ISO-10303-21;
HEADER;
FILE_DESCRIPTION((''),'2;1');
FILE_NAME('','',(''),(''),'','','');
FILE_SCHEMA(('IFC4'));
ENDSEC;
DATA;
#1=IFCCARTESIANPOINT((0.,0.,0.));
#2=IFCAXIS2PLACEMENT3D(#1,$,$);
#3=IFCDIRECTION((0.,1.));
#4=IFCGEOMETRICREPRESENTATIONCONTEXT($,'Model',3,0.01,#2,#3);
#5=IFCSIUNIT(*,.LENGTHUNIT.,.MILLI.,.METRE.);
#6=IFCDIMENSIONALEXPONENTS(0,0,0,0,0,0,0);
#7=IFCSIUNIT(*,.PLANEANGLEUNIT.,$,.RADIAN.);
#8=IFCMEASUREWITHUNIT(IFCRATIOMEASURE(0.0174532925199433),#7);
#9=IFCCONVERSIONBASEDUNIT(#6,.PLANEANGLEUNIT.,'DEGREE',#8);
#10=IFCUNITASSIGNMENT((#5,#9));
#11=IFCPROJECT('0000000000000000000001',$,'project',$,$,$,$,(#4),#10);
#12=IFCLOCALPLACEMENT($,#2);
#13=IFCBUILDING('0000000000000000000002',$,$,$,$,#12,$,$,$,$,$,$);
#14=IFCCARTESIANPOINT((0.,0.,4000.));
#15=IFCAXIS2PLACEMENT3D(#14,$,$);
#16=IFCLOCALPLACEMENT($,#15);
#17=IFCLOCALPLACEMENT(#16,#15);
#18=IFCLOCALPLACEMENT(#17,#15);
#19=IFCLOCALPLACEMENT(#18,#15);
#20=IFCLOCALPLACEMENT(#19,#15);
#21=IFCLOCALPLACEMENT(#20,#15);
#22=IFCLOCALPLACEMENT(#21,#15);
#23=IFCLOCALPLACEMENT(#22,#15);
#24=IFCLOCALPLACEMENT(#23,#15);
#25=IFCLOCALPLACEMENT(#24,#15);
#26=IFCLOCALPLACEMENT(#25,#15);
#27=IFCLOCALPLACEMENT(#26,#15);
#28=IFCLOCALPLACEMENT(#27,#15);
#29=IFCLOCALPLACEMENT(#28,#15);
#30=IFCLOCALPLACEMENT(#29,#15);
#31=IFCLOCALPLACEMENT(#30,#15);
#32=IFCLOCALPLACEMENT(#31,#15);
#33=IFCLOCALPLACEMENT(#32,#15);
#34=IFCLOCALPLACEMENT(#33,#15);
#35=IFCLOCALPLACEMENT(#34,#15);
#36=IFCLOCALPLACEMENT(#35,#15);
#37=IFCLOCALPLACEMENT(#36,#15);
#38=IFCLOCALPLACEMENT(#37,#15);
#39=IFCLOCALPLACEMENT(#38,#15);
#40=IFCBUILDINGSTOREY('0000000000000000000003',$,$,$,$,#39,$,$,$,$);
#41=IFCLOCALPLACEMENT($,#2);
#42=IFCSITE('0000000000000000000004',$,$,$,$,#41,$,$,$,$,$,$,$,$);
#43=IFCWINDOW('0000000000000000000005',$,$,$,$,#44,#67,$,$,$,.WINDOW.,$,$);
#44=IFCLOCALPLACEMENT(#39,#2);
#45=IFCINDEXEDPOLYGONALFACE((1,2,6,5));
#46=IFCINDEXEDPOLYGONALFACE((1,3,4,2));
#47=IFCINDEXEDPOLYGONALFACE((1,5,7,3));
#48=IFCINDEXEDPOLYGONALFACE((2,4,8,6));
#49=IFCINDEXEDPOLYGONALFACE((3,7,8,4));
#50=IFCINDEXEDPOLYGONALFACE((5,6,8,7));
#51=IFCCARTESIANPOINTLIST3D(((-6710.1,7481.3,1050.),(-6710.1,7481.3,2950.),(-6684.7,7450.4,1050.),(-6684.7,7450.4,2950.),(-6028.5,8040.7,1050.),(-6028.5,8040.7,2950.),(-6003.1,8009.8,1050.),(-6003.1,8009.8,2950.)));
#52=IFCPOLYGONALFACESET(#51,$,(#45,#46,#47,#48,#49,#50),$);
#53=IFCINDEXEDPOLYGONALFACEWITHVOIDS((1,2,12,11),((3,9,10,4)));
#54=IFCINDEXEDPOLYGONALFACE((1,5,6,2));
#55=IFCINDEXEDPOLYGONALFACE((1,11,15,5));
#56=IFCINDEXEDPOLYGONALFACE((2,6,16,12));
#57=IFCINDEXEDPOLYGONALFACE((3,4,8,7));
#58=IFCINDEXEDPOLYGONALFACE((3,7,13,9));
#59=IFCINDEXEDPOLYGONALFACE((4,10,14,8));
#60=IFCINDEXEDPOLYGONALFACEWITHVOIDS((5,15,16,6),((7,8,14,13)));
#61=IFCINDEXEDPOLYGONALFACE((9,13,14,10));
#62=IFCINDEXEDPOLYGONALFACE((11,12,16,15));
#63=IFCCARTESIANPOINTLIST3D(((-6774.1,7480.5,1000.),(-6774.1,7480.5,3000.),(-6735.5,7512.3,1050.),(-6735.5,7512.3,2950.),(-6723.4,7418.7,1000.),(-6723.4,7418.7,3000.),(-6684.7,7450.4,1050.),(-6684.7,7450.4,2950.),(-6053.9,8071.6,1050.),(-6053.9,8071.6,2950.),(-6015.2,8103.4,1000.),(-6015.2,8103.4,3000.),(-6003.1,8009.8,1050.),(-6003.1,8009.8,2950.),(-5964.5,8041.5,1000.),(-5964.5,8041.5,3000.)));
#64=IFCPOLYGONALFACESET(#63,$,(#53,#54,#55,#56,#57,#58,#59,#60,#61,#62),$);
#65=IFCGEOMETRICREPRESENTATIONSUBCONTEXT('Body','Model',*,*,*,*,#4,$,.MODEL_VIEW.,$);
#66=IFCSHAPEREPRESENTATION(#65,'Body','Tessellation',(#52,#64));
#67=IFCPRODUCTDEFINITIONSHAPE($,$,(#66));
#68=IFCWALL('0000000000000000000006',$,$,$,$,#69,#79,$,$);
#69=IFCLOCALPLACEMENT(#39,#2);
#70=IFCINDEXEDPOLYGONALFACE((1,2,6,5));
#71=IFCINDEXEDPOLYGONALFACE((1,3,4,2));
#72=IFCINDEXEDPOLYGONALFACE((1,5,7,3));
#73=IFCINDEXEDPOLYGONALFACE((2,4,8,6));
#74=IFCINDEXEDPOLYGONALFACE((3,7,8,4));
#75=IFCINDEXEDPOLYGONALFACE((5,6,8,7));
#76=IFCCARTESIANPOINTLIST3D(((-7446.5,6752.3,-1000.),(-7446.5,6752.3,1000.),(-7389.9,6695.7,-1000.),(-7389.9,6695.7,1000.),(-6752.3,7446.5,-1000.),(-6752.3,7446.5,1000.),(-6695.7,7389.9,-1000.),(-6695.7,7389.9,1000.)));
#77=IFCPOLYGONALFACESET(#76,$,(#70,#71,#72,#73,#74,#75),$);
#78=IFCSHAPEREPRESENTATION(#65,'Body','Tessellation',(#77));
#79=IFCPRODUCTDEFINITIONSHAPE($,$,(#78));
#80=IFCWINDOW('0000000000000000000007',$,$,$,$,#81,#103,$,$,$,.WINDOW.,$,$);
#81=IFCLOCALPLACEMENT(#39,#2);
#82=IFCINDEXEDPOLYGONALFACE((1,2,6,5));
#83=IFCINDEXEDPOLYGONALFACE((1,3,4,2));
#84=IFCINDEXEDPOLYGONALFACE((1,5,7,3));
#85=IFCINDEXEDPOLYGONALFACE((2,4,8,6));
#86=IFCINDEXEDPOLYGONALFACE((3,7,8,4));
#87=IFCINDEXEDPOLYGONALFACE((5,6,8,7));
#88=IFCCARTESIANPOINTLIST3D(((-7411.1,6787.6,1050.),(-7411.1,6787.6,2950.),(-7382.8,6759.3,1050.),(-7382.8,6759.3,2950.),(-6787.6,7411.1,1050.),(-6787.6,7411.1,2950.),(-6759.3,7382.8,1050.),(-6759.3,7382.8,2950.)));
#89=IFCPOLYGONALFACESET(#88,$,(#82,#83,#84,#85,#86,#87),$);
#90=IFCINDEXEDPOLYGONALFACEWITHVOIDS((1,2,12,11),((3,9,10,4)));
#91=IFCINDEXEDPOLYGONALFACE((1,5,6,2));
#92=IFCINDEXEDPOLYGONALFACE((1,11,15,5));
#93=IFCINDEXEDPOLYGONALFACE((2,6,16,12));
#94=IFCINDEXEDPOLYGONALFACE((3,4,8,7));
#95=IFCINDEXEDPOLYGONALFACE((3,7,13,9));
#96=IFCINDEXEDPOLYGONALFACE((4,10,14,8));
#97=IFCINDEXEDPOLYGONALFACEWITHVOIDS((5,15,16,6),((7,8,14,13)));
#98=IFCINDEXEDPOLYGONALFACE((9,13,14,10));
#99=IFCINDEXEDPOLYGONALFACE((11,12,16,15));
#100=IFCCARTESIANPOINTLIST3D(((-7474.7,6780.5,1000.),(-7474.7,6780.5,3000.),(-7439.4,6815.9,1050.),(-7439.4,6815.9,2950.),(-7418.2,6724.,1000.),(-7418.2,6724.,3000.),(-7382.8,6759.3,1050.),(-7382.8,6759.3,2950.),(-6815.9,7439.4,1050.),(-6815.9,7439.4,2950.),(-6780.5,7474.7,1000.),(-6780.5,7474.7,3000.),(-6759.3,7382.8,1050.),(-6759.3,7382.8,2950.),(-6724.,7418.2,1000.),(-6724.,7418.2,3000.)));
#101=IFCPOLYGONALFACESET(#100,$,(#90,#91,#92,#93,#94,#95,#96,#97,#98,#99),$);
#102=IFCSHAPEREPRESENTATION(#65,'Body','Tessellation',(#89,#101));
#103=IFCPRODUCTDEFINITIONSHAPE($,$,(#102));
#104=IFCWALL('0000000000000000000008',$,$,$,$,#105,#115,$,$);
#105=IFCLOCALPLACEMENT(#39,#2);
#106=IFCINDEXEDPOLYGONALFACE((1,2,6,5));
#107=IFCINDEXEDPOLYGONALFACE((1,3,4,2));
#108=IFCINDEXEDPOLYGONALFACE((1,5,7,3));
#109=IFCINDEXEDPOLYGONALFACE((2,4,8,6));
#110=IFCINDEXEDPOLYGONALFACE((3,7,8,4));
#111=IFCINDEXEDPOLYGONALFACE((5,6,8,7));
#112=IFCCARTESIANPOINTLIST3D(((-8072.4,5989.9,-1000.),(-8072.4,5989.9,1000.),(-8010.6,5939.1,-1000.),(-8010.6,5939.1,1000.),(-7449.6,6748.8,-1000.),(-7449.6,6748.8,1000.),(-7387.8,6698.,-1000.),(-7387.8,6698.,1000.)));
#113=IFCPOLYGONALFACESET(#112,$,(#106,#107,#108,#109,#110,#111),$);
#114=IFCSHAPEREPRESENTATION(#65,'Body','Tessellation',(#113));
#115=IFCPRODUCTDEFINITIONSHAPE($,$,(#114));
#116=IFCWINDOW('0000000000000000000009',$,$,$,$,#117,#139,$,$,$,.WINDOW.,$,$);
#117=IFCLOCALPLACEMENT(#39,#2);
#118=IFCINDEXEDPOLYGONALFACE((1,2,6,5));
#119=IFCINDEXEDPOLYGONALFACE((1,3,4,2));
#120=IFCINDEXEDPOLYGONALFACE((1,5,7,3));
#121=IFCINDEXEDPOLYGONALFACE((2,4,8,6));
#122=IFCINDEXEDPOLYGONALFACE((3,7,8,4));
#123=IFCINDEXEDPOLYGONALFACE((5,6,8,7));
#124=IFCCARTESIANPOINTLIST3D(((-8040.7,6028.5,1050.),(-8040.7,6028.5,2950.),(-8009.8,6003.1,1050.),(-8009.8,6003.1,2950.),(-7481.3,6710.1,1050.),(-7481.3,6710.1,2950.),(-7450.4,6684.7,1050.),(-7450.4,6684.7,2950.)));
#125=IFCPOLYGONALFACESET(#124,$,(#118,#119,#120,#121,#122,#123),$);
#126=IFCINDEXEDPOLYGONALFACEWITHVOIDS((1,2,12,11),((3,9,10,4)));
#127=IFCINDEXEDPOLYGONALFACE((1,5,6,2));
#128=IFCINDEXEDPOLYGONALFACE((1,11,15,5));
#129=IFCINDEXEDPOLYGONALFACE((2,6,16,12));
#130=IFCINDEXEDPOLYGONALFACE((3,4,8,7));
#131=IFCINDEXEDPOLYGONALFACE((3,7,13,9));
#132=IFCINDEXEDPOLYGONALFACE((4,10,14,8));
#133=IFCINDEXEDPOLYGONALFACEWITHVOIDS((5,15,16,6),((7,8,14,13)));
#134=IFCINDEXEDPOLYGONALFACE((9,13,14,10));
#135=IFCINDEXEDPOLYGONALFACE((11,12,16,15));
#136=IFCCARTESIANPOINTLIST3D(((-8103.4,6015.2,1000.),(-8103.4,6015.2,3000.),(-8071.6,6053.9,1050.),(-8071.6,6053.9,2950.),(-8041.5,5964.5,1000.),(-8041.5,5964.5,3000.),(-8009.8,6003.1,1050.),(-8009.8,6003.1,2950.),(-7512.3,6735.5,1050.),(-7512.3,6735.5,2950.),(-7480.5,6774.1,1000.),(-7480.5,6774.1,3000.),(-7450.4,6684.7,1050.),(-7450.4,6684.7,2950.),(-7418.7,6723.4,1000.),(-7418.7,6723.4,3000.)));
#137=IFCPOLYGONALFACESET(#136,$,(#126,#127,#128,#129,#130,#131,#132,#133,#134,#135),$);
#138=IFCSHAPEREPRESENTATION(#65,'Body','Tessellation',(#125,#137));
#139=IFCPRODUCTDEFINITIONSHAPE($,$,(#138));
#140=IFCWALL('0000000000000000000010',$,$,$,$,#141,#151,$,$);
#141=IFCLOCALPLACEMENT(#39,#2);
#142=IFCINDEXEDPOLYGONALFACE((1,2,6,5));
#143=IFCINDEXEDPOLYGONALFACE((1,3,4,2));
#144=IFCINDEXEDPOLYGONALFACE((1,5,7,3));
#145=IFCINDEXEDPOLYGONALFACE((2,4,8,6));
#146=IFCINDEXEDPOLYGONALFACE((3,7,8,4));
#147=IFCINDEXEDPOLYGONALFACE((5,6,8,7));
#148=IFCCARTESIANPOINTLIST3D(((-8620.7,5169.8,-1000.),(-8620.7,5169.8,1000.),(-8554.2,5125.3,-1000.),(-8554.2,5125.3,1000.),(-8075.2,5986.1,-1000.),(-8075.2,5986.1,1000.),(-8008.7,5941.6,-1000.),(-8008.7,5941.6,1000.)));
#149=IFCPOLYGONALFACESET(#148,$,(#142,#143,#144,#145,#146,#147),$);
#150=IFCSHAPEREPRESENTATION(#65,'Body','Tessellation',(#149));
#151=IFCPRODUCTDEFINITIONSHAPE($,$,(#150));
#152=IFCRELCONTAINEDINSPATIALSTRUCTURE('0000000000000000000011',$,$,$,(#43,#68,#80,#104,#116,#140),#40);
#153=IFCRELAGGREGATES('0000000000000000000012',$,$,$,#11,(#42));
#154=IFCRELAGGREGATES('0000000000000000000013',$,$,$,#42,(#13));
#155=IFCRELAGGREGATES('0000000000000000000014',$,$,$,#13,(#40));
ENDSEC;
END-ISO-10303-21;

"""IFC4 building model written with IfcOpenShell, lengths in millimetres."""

from ifc_helpers import new_model, entity, si_unit, converted_unit, direction, frame, origin, origin_2d, place, context, subcontext, project, spatial, rectangle, extrude, element, save


model = new_model("IFC4")

# Units and contexts
model_context = context("Model", 3, precision=0.01, world=origin(), true_north=direction((0.0, 1.0)))
body_context = subcontext(model_context, "Body", "Model", "MODEL_VIEW")
ifc_project = project(units=[si_unit("LENGTHUNIT", "METRE", prefix="MILLI"), converted_unit("PLANEANGLEUNIT", "DEGREE", entity("IfcRatioMeasure", 0.0174532925199433), si_unit("PLANEANGLEUNIT", "RADIAN"), dimensions=[0, 0, 0, 0, 0, 0, 0])], contexts=[model_context])

# Site, building, storey
site_placement = place(None, origin())
site = spatial("IfcSite", under=ifc_project, at=site_placement)
building_placement = place(None, origin())
building = spatial("IfcBuilding", under=site, at=building_placement)
placement_1 = place(None, frame((0.0, 0.0, 4000.0)))
placement_2 = place(placement_1, frame((0.0, 0.0, 4000.0)))
placement_3 = place(placement_2, frame((0.0, 0.0, 4000.0)))
placement_4 = place(placement_3, frame((0.0, 0.0, 4000.0)))
placement_5 = place(placement_4, frame((0.0, 0.0, 4000.0)))
placement_6 = place(placement_5, frame((0.0, 0.0, 4000.0)))
placement_7 = place(placement_6, frame((0.0, 0.0, 4000.0)))
placement_8 = place(placement_7, frame((0.0, 0.0, 4000.0)))
placement_9 = place(placement_8, frame((0.0, 0.0, 4000.0)))
placement_10 = place(placement_9, frame((0.0, 0.0, 4000.0)))
placement_11 = place(placement_10, frame((0.0, 0.0, 4000.0)))
placement_12 = place(placement_11, frame((0.0, 0.0, 4000.0)))
placement_13 = place(placement_12, frame((0.0, 0.0, 4000.0)))
placement_14 = place(placement_13, frame((0.0, 0.0, 4000.0)))
placement_15 = place(placement_14, frame((0.0, 0.0, 4000.0)))
placement_16 = place(placement_15, frame((0.0, 0.0, 4000.0)))
placement_17 = place(placement_16, frame((0.0, 0.0, 4000.0)))
placement_18 = place(placement_17, frame((0.0, 0.0, 4000.0)))
placement_19 = place(placement_18, frame((0.0, 0.0, 4000.0)))
placement_20 = place(placement_19, frame((0.0, 0.0, 4000.0)))
placement_21 = place(placement_20, frame((0.0, 0.0, 4000.0)))
placement_22 = place(placement_21, frame((0.0, 0.0, 4000.0)))
placement_23 = place(placement_22, frame((0.0, 0.0, 4000.0)))
storey_placement = place(placement_23, frame((0.0, 0.0, 4000.0)))
storey = spatial("IfcBuildingStorey", under=building, at=storey_placement)

# Shared definitions
cartesian_point_1 = entity("IfcCartesianPoint", [-440.9, -950.0])
shared_polyline = entity("IfcPolyline", [cartesian_point_1, entity("IfcCartesianPoint", [-440.9, 950.0]), entity("IfcCartesianPoint", [-440.9, 950.0]), entity("IfcCartesianPoint", [440.9, 950.0]), entity("IfcCartesianPoint", [440.9, 950.0]), entity("IfcCartesianPoint", [440.9, -950.0]), entity("IfcCartesianPoint", [440.9, -950.0]), entity("IfcCartesianPoint", [-440.9, -950.0]), cartesian_point_1])

# Window
window_1_placement = place(storey_placement, frame((-6343.9, 7730.1, 2000.0), z_axis=(0.0, 0.0, 1.0), x_axis=(-7730.104749, -6343.932579, 0.0)))
cartesian_point_2 = entity("IfcCartesianPoint", [-490.9, -1000.0])
element("IfcWindow", 1, at=window_1_placement, inside=storey, PredefinedType="WINDOW", context=body_context, shape_type="SweptSolid", body=[
    entity("IfcExtrudedAreaSolid", entity("IfcArbitraryClosedProfileDef", "AREA", None, shared_polyline), entity("IfcAxis2Placement3D", entity("IfcCartesianPoint", [0.0, 0.0, 0.0]), entity("IfcDirection", [0.0, -1.0, 0.0]), entity("IfcDirection", [1.0, 0.0, 0.0])), entity("IfcDirection", [0.0, 0.0, 1.0]), 40.0),
    entity("IfcExtrudedAreaSolid", entity("IfcArbitraryProfileDefWithVoids", "AREA", None, entity("IfcPolyline", [cartesian_point_2, entity("IfcCartesianPoint", [-490.9, 1000.0]), entity("IfcCartesianPoint", [-490.9, 1000.0]), entity("IfcCartesianPoint", [490.9, 1000.0]), entity("IfcCartesianPoint", [490.9, 1000.0]), entity("IfcCartesianPoint", [490.9, -1000.0]), entity("IfcCartesianPoint", [490.9, -1000.0]), entity("IfcCartesianPoint", [-490.9, -1000.0]), cartesian_point_2]), [shared_polyline]), entity("IfcAxis2Placement3D", entity("IfcCartesianPoint", [0.0, 0.0, 0.0]), entity("IfcDirection", [0.0, -1.0, 0.0]), entity("IfcDirection", [1.0, 0.0, 0.0])), entity("IfcDirection", [0.0, 0.0, 1.0]), 80.0),
])

# Wall
wall_1_placement = place(storey_placement, frame((-7071.1, 7071.1, -1000.0), z_axis=(0.0, 0.0, 1.0), x_axis=(-7071.06777, -7071.067854, 0.0)))
element("IfcWall", 2, at=wall_1_placement, inside=storey, context=body_context, shape_type="SweptSolid", body=[
    extrude(rectangle(XDim=981.7, YDim=80.0, at=origin_2d()), origin(), (0.0, 0.0, 1.0), 2000.0),
])

# Window
window_2_placement = place(storey_placement, frame((-7071.1, 7071.1, 2000.0), z_axis=(0.0, 0.0, 1.0), x_axis=(-7071.06777, -7071.067854, 0.0)))
cartesian_point_3 = entity("IfcCartesianPoint", [-490.9, -1000.0])
element("IfcWindow", 3, at=window_2_placement, inside=storey, PredefinedType="WINDOW", context=body_context, shape_type="SweptSolid", body=[
    entity("IfcExtrudedAreaSolid", entity("IfcArbitraryClosedProfileDef", "AREA", None, shared_polyline), entity("IfcAxis2Placement3D", entity("IfcCartesianPoint", [0.0, 0.0, 0.0]), entity("IfcDirection", [0.0, -1.0, 0.0]), entity("IfcDirection", [1.0, 0.0, 0.0])), entity("IfcDirection", [0.0, 0.0, 1.0]), 40.0),
    entity("IfcExtrudedAreaSolid", entity("IfcArbitraryProfileDefWithVoids", "AREA", None, entity("IfcPolyline", [cartesian_point_3, entity("IfcCartesianPoint", [-490.9, 1000.0]), entity("IfcCartesianPoint", [-490.9, 1000.0]), entity("IfcCartesianPoint", [490.9, 1000.0]), entity("IfcCartesianPoint", [490.9, 1000.0]), entity("IfcCartesianPoint", [490.9, -1000.0]), entity("IfcCartesianPoint", [490.9, -1000.0]), entity("IfcCartesianPoint", [-490.9, -1000.0]), cartesian_point_3]), [shared_polyline]), entity("IfcAxis2Placement3D", entity("IfcCartesianPoint", [0.0, 0.0, 0.0]), entity("IfcDirection", [0.0, -1.0, 0.0]), entity("IfcDirection", [1.0, 0.0, 0.0])), entity("IfcDirection", [0.0, 0.0, 1.0]), 80.0),
])

# Wall
wall_2_placement = place(storey_placement, frame((-7730.1, 6343.9, -1000.0), z_axis=(0.0, 0.0, 1.0), x_axis=(-6343.932486, -7730.104825, 0.0)))
element("IfcWall", 4, at=wall_2_placement, inside=storey, context=body_context, shape_type="SweptSolid", body=[
    extrude(rectangle(XDim=981.7, YDim=80.0, at=origin_2d()), origin(), (0.0, 0.0, 1.0), 2000.0),
])

# Window
window_3_placement = place(storey_placement, frame((-7730.1, 6343.9, 2000.0), z_axis=(0.0, 0.0, 1.0), x_axis=(-6343.932486, -7730.104825, 0.0)))
cartesian_point_4 = entity("IfcCartesianPoint", [-490.9, -1000.0])
element("IfcWindow", 5, at=window_3_placement, inside=storey, PredefinedType="WINDOW", context=body_context, shape_type="SweptSolid", body=[
    entity("IfcExtrudedAreaSolid", entity("IfcArbitraryClosedProfileDef", "AREA", None, shared_polyline), entity("IfcAxis2Placement3D", entity("IfcCartesianPoint", [0.0, 0.0, 0.0]), entity("IfcDirection", [0.0, -1.0, 0.0]), entity("IfcDirection", [1.0, 0.0, 0.0])), entity("IfcDirection", [0.0, 0.0, 1.0]), 40.0),
    entity("IfcExtrudedAreaSolid", entity("IfcArbitraryProfileDefWithVoids", "AREA", None, entity("IfcPolyline", [cartesian_point_4, entity("IfcCartesianPoint", [-490.9, 1000.0]), entity("IfcCartesianPoint", [-490.9, 1000.0]), entity("IfcCartesianPoint", [490.9, 1000.0]), entity("IfcCartesianPoint", [490.9, 1000.0]), entity("IfcCartesianPoint", [490.9, -1000.0]), entity("IfcCartesianPoint", [490.9, -1000.0]), entity("IfcCartesianPoint", [-490.9, -1000.0]), cartesian_point_4]), [shared_polyline]), entity("IfcAxis2Placement3D", entity("IfcCartesianPoint", [0.0, 0.0, 0.0]), entity("IfcDirection", [0.0, -1.0, 0.0]), entity("IfcDirection", [1.0, 0.0, 0.0])), entity("IfcDirection", [0.0, 0.0, 1.0]), 80.0),
])

# Wall
wall_3_placement = place(storey_placement, frame((-8314.7, 5555.7, -1000.0), z_axis=(0.0, 0.0, 1.0), x_axis=(-5555.701616, -8314.6966, 0.0)))
element("IfcWall", 6, at=wall_3_placement, inside=storey, context=body_context, shape_type="SweptSolid", body=[
    extrude(rectangle(XDim=981.7, YDim=80.0, at=origin_2d()), origin(), (0.0, 0.0, 1.0), 2000.0),
])

save(model, "model.ifc")
